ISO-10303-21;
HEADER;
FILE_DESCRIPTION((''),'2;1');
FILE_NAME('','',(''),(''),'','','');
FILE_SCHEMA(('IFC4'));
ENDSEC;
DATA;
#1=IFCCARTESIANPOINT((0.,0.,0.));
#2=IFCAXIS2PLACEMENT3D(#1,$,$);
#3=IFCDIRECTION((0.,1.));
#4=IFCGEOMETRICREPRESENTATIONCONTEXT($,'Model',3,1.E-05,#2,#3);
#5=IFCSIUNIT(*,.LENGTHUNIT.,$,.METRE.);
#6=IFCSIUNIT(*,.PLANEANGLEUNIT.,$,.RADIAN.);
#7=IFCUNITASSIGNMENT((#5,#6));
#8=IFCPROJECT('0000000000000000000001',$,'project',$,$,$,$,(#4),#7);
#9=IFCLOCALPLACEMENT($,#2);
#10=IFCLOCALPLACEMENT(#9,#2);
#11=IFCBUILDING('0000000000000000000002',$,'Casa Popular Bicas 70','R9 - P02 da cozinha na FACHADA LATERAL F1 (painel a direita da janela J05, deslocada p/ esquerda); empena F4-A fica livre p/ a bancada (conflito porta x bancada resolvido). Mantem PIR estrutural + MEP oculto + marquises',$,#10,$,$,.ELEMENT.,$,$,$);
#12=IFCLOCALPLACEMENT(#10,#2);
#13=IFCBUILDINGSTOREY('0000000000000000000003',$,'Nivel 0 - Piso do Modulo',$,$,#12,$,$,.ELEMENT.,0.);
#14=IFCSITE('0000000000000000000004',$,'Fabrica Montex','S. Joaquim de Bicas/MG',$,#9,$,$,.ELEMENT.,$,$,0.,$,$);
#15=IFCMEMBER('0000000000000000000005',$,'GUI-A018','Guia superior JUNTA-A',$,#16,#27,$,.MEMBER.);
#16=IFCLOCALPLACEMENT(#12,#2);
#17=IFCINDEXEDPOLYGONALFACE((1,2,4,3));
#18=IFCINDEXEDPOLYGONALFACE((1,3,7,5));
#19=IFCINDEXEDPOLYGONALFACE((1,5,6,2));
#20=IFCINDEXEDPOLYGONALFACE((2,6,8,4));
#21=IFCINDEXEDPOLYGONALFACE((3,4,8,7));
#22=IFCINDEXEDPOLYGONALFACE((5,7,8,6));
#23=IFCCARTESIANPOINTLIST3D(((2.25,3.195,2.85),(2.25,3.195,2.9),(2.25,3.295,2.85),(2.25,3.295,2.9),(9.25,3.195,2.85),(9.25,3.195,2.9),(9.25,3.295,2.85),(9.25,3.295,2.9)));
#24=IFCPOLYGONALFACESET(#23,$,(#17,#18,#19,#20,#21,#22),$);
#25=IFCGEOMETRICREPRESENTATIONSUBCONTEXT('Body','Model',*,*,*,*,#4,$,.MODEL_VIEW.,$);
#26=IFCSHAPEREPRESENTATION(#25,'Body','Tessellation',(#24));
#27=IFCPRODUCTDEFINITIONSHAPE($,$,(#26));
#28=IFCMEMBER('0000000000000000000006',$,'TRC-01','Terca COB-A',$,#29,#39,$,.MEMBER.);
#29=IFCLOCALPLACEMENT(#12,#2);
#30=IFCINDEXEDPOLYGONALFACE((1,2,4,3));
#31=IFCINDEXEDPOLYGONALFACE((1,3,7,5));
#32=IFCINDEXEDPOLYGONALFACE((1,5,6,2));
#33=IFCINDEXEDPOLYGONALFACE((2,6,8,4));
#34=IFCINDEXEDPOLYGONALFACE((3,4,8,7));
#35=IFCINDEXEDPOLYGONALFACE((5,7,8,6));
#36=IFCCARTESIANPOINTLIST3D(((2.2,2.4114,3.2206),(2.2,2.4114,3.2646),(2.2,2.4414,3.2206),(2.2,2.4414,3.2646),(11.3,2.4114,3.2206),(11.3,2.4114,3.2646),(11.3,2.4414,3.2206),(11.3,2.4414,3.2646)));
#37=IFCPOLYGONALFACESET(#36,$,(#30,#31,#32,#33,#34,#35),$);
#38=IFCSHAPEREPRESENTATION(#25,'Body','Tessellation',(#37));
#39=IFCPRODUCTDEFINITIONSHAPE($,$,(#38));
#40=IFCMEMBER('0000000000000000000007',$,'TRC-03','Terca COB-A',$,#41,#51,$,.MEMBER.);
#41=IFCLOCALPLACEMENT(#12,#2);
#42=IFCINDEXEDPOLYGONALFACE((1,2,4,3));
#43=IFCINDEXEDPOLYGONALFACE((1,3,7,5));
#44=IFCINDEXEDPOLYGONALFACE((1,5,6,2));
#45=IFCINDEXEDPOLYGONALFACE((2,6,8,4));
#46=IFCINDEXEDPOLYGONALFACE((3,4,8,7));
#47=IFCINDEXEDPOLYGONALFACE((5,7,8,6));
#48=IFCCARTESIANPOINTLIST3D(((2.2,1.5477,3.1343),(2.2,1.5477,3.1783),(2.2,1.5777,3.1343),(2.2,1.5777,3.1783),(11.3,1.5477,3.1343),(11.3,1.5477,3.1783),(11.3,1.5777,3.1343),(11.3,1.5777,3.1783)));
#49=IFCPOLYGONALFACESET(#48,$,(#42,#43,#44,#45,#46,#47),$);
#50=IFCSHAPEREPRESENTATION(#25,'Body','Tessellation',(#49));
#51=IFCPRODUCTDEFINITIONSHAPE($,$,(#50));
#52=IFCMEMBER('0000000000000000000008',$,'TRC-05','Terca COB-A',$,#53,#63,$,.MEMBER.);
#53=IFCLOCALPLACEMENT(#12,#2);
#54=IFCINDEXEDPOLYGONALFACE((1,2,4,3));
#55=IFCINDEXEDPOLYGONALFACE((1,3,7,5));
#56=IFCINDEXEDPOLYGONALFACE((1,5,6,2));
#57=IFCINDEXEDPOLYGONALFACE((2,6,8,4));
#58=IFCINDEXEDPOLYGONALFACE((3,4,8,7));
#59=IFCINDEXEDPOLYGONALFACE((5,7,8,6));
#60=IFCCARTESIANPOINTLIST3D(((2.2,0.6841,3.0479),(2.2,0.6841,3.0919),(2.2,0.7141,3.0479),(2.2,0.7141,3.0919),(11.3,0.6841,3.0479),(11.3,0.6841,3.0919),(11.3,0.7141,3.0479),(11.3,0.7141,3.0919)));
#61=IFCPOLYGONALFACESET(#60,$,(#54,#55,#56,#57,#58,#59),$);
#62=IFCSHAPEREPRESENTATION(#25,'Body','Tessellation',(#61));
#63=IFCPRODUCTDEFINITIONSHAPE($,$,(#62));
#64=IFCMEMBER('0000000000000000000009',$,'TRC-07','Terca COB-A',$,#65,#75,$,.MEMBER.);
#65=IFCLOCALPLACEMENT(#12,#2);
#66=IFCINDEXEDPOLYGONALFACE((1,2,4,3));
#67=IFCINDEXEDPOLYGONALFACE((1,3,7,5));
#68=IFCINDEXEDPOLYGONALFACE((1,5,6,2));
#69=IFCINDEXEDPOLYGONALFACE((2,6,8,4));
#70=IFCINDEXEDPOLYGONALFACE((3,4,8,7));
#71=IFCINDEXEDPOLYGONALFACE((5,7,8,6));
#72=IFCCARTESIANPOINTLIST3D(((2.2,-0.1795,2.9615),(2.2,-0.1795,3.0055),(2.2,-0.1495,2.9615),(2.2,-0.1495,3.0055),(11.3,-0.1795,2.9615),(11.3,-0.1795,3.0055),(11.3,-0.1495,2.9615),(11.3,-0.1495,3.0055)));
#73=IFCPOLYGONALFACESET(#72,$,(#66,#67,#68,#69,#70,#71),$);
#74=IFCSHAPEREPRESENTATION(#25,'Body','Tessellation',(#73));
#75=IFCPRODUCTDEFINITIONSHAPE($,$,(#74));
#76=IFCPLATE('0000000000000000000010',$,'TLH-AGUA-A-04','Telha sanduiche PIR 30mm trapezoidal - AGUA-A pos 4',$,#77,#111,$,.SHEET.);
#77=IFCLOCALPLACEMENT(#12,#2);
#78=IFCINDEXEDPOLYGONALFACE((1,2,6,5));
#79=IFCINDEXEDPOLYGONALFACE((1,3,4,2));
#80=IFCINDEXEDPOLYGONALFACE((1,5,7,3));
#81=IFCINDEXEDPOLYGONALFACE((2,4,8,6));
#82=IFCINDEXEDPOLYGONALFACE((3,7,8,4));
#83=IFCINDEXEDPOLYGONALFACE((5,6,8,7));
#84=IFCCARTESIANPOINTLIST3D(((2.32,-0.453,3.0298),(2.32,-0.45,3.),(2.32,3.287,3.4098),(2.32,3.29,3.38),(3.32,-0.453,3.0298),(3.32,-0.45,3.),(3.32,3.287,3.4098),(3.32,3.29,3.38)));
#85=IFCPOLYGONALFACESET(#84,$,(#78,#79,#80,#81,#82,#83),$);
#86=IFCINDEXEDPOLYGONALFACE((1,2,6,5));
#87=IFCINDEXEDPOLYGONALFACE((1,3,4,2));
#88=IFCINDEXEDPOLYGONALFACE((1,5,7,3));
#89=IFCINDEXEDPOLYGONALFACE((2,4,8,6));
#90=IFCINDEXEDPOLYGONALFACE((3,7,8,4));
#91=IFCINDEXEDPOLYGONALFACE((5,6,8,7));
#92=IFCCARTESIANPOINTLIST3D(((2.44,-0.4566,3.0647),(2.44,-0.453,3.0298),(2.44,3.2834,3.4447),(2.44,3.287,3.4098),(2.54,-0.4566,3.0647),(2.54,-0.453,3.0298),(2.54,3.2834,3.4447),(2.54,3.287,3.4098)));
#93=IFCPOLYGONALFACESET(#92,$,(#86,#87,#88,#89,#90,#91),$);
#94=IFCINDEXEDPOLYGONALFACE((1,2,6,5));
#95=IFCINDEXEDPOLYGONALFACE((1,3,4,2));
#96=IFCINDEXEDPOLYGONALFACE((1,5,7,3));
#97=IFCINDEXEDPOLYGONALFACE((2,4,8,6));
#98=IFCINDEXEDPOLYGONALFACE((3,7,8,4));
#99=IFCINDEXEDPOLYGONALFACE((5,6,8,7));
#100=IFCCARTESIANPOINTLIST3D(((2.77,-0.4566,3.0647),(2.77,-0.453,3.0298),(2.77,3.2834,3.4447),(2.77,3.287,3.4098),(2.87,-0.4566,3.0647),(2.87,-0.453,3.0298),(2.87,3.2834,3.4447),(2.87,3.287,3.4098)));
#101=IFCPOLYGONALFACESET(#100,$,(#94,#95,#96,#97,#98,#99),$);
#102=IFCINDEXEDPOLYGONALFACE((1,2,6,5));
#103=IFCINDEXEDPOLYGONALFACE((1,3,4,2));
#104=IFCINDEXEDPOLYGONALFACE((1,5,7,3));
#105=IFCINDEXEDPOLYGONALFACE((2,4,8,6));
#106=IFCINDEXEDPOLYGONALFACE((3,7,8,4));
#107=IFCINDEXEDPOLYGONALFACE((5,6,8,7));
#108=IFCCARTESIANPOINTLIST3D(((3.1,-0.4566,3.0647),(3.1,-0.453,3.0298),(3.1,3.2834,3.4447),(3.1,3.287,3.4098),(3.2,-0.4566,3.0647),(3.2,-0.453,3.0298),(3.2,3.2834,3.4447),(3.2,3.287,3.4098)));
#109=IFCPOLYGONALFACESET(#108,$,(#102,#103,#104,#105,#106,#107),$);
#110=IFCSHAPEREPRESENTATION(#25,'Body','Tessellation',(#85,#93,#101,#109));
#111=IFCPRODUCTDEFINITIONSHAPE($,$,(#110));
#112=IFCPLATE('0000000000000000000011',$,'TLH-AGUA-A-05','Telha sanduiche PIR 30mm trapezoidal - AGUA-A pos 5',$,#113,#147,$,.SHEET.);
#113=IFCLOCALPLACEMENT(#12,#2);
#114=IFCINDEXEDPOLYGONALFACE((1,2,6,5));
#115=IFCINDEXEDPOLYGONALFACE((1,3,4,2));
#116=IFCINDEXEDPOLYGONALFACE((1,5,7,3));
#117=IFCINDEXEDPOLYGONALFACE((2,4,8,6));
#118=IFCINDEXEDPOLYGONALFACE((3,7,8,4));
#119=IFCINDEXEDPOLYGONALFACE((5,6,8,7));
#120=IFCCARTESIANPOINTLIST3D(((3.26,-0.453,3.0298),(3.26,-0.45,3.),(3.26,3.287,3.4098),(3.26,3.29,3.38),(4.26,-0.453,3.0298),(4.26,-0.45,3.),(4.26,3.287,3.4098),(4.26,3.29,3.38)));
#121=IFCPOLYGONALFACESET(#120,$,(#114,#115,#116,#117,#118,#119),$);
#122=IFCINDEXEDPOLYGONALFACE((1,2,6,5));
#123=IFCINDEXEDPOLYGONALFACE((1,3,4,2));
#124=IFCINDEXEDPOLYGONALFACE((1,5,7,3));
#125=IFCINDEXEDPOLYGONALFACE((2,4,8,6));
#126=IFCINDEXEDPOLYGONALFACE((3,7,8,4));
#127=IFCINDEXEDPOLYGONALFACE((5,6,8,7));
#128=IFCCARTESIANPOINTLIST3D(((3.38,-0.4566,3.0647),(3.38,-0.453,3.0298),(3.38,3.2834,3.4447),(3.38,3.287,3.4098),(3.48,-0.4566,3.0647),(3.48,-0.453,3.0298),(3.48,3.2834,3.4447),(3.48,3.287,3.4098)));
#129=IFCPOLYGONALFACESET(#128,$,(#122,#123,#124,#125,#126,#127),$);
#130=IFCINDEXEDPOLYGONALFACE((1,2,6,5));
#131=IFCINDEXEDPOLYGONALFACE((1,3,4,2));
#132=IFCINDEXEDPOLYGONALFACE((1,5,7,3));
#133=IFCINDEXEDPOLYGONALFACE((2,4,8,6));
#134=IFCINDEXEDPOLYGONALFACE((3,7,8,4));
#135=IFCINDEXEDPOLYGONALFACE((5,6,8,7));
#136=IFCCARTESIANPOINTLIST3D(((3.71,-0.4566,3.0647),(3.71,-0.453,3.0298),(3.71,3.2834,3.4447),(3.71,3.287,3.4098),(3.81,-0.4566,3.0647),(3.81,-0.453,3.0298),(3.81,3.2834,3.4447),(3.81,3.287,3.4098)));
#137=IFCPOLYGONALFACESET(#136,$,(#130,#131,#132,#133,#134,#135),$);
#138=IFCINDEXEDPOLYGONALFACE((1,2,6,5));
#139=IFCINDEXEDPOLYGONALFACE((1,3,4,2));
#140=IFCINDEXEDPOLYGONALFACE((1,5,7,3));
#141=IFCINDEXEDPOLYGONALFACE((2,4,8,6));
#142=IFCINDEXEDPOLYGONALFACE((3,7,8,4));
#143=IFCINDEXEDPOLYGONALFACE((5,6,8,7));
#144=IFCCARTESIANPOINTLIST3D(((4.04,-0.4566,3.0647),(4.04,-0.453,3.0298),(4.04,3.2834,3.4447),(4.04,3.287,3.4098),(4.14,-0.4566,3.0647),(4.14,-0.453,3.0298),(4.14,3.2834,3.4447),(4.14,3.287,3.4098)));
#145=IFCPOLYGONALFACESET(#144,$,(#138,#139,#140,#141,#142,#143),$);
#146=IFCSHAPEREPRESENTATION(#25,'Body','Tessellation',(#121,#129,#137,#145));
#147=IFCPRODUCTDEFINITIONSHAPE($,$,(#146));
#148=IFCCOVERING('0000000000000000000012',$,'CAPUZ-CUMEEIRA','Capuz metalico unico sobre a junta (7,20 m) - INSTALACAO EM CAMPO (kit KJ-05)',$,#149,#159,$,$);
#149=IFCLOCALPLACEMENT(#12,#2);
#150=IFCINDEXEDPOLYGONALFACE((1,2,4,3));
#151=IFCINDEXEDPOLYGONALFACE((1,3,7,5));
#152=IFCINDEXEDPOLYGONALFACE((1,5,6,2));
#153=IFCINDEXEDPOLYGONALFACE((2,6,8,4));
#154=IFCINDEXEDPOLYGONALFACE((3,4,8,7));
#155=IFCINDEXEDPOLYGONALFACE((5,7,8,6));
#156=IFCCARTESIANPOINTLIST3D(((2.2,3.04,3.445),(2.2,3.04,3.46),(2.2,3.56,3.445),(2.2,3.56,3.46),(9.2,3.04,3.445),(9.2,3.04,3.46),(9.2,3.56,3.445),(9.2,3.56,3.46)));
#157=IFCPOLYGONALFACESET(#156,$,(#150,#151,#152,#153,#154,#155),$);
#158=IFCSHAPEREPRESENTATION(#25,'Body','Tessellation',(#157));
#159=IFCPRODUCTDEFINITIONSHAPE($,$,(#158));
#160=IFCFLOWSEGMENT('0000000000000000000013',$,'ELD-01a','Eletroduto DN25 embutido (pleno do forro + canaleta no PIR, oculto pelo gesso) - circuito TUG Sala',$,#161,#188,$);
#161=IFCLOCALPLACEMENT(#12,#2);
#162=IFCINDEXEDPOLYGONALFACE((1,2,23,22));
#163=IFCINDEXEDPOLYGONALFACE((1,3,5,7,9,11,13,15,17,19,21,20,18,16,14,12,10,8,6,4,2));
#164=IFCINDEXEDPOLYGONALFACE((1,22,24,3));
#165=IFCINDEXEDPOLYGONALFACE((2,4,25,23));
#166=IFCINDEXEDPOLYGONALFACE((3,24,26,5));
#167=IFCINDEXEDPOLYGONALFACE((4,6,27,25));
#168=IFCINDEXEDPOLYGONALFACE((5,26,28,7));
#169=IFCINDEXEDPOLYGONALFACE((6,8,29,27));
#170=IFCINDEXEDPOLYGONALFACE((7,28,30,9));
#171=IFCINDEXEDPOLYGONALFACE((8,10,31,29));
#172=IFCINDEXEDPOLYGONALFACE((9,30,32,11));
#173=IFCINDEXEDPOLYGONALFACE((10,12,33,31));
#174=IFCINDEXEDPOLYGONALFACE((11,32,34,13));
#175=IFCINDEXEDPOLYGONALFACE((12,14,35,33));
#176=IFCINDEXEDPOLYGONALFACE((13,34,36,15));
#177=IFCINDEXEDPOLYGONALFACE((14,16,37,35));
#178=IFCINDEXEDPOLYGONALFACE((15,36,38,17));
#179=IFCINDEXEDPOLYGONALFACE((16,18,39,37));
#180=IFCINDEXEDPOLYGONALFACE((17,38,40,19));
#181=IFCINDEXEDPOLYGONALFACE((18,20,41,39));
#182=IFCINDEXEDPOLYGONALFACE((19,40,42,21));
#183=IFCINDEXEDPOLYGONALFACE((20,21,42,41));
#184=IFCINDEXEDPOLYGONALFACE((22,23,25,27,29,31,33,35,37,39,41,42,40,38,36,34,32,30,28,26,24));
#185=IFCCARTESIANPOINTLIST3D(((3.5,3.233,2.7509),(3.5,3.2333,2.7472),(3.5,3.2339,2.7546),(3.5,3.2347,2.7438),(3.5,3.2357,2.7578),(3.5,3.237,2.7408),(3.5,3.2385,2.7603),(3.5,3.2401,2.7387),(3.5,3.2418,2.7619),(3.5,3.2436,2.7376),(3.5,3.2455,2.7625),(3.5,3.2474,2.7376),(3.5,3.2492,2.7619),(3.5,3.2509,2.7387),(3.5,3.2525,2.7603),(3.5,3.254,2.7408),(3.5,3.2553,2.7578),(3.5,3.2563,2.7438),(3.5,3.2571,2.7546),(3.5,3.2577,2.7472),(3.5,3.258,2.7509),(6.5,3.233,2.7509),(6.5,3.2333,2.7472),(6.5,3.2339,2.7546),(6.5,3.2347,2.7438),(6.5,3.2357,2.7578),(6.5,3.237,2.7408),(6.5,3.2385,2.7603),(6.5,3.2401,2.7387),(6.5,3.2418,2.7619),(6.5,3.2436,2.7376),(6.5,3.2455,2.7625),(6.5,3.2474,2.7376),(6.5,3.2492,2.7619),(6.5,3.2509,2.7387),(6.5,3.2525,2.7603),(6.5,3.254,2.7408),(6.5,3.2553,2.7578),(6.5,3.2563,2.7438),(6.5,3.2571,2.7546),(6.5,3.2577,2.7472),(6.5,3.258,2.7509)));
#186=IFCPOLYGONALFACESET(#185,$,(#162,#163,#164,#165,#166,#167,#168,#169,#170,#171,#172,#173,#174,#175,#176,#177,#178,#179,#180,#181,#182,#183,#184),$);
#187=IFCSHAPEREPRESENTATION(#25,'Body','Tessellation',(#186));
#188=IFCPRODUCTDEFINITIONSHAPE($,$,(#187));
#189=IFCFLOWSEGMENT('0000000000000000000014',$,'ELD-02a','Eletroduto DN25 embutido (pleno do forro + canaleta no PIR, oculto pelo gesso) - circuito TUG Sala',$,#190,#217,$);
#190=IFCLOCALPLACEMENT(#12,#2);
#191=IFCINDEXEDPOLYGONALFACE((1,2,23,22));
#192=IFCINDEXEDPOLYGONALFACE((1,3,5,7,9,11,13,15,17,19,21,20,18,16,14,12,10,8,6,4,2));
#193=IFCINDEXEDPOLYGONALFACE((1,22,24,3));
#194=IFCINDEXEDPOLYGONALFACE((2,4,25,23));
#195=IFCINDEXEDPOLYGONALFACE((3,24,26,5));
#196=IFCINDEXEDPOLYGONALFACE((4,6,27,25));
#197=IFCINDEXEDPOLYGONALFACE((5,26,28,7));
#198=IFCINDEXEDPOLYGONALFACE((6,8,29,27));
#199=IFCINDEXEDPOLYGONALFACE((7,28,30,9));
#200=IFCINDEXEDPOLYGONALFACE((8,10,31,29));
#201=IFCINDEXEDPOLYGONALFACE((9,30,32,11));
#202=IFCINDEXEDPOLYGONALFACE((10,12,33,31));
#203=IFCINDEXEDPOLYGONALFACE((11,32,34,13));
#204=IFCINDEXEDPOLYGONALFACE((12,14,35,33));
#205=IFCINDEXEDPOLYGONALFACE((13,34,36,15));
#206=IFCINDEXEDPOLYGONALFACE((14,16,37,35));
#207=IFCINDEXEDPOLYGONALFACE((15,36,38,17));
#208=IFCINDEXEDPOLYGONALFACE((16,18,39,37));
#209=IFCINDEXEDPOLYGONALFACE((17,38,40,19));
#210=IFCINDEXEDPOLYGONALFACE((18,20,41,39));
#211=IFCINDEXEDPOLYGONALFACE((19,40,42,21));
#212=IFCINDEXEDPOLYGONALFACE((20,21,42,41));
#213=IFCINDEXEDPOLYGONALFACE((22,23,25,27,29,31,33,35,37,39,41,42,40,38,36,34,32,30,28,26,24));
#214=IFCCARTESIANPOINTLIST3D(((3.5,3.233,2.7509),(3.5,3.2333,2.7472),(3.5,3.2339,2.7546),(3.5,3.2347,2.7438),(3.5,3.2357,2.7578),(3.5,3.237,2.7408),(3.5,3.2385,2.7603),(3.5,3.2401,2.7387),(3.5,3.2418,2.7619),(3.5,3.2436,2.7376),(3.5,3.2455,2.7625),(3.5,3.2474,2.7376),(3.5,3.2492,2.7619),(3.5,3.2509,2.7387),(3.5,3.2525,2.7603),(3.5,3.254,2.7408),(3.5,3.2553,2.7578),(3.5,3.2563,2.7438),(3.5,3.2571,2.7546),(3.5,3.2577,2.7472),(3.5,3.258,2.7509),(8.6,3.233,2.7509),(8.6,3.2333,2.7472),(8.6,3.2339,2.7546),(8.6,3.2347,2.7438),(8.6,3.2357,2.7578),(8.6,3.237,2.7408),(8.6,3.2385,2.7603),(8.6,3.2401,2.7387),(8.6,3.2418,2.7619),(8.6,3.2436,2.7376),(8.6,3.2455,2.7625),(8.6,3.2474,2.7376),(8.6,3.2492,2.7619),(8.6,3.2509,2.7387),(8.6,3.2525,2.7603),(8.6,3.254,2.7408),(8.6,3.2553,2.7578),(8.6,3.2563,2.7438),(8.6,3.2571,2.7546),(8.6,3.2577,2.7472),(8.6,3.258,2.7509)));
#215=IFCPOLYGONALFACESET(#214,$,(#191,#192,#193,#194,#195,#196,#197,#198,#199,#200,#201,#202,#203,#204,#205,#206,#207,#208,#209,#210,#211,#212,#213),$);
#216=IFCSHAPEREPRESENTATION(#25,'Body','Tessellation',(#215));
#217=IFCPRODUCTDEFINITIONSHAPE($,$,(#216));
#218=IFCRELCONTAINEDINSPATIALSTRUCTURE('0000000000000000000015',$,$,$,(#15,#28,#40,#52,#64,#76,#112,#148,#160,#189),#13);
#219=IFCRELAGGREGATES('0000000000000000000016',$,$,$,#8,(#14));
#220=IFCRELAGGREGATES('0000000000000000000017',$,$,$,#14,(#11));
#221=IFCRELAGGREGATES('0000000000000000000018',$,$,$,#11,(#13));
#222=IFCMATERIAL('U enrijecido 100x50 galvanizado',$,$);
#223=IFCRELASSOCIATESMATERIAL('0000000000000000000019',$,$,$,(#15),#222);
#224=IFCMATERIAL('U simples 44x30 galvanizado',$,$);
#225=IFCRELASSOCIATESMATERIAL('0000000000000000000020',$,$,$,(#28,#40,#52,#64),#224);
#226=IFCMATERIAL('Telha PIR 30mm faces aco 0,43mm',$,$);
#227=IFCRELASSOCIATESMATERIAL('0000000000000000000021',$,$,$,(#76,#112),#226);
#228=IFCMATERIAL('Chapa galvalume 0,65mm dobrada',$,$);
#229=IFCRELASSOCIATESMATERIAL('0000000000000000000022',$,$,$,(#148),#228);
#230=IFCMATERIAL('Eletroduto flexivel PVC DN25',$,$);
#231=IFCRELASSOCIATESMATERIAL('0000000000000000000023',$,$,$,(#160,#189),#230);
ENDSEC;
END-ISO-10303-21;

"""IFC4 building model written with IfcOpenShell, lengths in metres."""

from ifc_helpers import new_model, si_unit, direction, frame, frame_2d, origin, origin_2d, place, context, subcontext, project, spatial, rectangle, circle, extrude, material, element, save


model = new_model("IFC4")

# Units and contexts
model_context = context("Model", 3, precision=1e-05, world=origin(), true_north=direction((0.0, 1.0)))
body_context = subcontext(model_context, "Body", "Model", "MODEL_VIEW")
ifc_project = project(units=[si_unit("LENGTHUNIT", "METRE"), si_unit("PLANEANGLEUNIT", "RADIAN")], contexts=[model_context])

# Site, building, storey
site_placement = place(None, origin())
site = spatial("IfcSite", under=ifc_project, at=site_placement, Name="Fabrica Montex", Description="S. Joaquim de Bicas/MG", CompositionType="ELEMENT", RefElevation=0.0)
building_placement = place(site_placement, origin())
building = spatial("IfcBuilding", under=site, at=building_placement, Name="Casa Popular Bicas 70", Description="R9 - P02 da cozinha na FACHADA LATERAL F1 (painel a direita da janela J05, deslocada p/ esquerda); empena F4-A fica livre p/ a bancada (conflito porta x bancada resolvido). Mantem PIR estrutural + MEP oculto + marquises", CompositionType="ELEMENT")
storey_placement = place(building_placement, origin())
storey = spatial("IfcBuildingStorey", under=building, at=storey_placement, Name="Nivel 0 - Piso do Modulo", CompositionType="ELEMENT", Elevation=0.0)

# Members
ifc_material_1 = material(Name="U enrijecido 100x50 galvanizado")
member_placement = place(storey_placement, frame((2.25, 3.245, 2.875), z_axis=(1.0, 0.0, 0.0), x_axis=(0.0, 0.0, 1.0)))
element("IfcMember", 1, at=member_placement, inside=storey, material=ifc_material_1, Name="GUI-A018", Description="Guia superior JUNTA-A", PredefinedType="MEMBER", context=body_context, shape_type="SweptSolid", body=[
    extrude(rectangle(XDim=0.05, YDim=0.1, at=origin_2d()), origin(), (0.0, 0.0, 1.0), 7.0),
])
ifc_material_2 = material(Name="U simples 44x30 galvanizado")
for number, where, z_axis, x_axis, name in (
    (2, (2.2, 2.4264, 3.2426), (1.0, 0.0, 0.0), (0.0, 0.0, 1.0), "TRC-01"),
    (3, (2.2, 1.5627, 3.1563), (1.0, 0.0, 0.0), (0.0, 0.0, 1.0), "TRC-03"),
    (4, (2.2, 0.6991, 3.0699), (1.0, 0.0, 0.0), (0.0, 0.0, 1.0), "TRC-05"),
    (5, (2.2, -0.1645, 2.9835), (1.0, 0.0, 0.0), (0.0, 0.0, 1.0), "TRC-07"),
):
    element("IfcMember", number, at=place(storey_placement, frame(where, z_axis=z_axis, x_axis=x_axis)), inside=storey, material=ifc_material_2, Name=name, Description="Terca COB-A", PredefinedType="MEMBER", context=body_context, shape_type="SweptSolid", body=[
        extrude(rectangle(XDim=0.044, YDim=0.03, at=origin_2d()), origin(), (0.0, 0.0, 1.0), 9.1),
    ])

# Plates
ifc_material_3 = material(Name="Telha PIR 30mm faces aco 0,43mm")
for number, where, z_axis, x_axis, name, description in (
    (6, (2.32, -0.45, 3.0), (0.0, -0.101084, 0.994878), (1.0, 0.0, 0.0), "TLH-AGUA-A-04", "Telha sanduiche PIR 30mm trapezoidal - AGUA-A pos 4"),
    (7, (3.26, -0.45, 3.0), (0.0, -0.101084, 0.994878), (1.0, 0.0, 0.0), "TLH-AGUA-A-05", "Telha sanduiche PIR 30mm trapezoidal - AGUA-A pos 5"),
):
    element("IfcPlate", number, at=place(storey_placement, frame(where, z_axis=z_axis, x_axis=x_axis)), inside=storey, material=ifc_material_3, Name=name, Description=description, PredefinedType="SHEET", context=body_context, shape_type="SweptSolid", body=[
        extrude(rectangle(XDim=1.0, YDim=3.7593, at=frame_2d((0.5, 1.8796))), origin(), (0.0, 0.0, 1.0), 0.03),
        extrude(rectangle(XDim=0.1, YDim=3.7593, at=frame_2d((0.17, 1.8796))), frame((0.0, 0.0, 0.03)), (0.0, 0.0, 1.0), 0.035),
        extrude(rectangle(XDim=0.1, YDim=3.7593, at=frame_2d((0.5, 1.8796))), frame((0.0, 0.0, 0.03)), (0.0, 0.0, 1.0), 0.035),
        extrude(rectangle(XDim=0.1, YDim=3.7593, at=frame_2d((0.83, 1.8796))), frame((0.0, 0.0, 0.03)), (0.0, 0.0, 1.0), 0.035),
    ])

# Covering
ifc_material_4 = material(Name="Chapa galvalume 0,65mm dobrada")
covering_placement = place(storey_placement, frame((2.2, 3.04, 3.445), x_axis=(1.0, 0.0, 0.0)))
element("IfcCovering", 8, at=covering_placement, inside=storey, material=ifc_material_4, Name="CAPUZ-CUMEEIRA", Description="Capuz metalico unico sobre a junta (7,20 m) - INSTALACAO EM CAMPO (kit KJ-05)", context=body_context, shape_type="SweptSolid", body=[
    extrude(rectangle(XDim=7.0, YDim=0.52, at=frame_2d((3.5, 0.26))), origin(), (0.0, 0.0, 1.0), 0.015),
])

# Flow segments
ifc_material_5 = material(Name="Eletroduto flexivel PVC DN25")
flow_segment_1_placement = place(storey_placement, frame((3.5, 3.2455, 2.75), z_axis=(1.0, 0.0, 0.0), x_axis=(0.0, 0.0, 1.0)))
element("IfcFlowSegment", 9, at=flow_segment_1_placement, inside=storey, material=ifc_material_5, Name="ELD-01a", Description="Eletroduto DN25 embutido (pleno do forro + canaleta no PIR, oculto pelo gesso) - circuito TUG Sala", context=body_context, shape_type="SweptSolid", body=[
    extrude(circle(Radius=0.0125, at=origin_2d()), origin(), (0.0, 0.0, 1.0), 3.0),
])
flow_segment_2_placement = place(storey_placement, frame((3.5, 3.2455, 2.75), z_axis=(1.0, 0.0, 0.0), x_axis=(0.0, 0.0, 1.0)))
element("IfcFlowSegment", 10, at=flow_segment_2_placement, inside=storey, material=ifc_material_5, Name="ELD-02a", Description="Eletroduto DN25 embutido (pleno do forro + canaleta no PIR, oculto pelo gesso) - circuito TUG Sala", context=body_context, shape_type="SweptSolid", body=[
    extrude(circle(Radius=0.0125, at=origin_2d()), origin(), (0.0, 0.0, 1.0), 5.1),
])

save(model, "model.ifc")
